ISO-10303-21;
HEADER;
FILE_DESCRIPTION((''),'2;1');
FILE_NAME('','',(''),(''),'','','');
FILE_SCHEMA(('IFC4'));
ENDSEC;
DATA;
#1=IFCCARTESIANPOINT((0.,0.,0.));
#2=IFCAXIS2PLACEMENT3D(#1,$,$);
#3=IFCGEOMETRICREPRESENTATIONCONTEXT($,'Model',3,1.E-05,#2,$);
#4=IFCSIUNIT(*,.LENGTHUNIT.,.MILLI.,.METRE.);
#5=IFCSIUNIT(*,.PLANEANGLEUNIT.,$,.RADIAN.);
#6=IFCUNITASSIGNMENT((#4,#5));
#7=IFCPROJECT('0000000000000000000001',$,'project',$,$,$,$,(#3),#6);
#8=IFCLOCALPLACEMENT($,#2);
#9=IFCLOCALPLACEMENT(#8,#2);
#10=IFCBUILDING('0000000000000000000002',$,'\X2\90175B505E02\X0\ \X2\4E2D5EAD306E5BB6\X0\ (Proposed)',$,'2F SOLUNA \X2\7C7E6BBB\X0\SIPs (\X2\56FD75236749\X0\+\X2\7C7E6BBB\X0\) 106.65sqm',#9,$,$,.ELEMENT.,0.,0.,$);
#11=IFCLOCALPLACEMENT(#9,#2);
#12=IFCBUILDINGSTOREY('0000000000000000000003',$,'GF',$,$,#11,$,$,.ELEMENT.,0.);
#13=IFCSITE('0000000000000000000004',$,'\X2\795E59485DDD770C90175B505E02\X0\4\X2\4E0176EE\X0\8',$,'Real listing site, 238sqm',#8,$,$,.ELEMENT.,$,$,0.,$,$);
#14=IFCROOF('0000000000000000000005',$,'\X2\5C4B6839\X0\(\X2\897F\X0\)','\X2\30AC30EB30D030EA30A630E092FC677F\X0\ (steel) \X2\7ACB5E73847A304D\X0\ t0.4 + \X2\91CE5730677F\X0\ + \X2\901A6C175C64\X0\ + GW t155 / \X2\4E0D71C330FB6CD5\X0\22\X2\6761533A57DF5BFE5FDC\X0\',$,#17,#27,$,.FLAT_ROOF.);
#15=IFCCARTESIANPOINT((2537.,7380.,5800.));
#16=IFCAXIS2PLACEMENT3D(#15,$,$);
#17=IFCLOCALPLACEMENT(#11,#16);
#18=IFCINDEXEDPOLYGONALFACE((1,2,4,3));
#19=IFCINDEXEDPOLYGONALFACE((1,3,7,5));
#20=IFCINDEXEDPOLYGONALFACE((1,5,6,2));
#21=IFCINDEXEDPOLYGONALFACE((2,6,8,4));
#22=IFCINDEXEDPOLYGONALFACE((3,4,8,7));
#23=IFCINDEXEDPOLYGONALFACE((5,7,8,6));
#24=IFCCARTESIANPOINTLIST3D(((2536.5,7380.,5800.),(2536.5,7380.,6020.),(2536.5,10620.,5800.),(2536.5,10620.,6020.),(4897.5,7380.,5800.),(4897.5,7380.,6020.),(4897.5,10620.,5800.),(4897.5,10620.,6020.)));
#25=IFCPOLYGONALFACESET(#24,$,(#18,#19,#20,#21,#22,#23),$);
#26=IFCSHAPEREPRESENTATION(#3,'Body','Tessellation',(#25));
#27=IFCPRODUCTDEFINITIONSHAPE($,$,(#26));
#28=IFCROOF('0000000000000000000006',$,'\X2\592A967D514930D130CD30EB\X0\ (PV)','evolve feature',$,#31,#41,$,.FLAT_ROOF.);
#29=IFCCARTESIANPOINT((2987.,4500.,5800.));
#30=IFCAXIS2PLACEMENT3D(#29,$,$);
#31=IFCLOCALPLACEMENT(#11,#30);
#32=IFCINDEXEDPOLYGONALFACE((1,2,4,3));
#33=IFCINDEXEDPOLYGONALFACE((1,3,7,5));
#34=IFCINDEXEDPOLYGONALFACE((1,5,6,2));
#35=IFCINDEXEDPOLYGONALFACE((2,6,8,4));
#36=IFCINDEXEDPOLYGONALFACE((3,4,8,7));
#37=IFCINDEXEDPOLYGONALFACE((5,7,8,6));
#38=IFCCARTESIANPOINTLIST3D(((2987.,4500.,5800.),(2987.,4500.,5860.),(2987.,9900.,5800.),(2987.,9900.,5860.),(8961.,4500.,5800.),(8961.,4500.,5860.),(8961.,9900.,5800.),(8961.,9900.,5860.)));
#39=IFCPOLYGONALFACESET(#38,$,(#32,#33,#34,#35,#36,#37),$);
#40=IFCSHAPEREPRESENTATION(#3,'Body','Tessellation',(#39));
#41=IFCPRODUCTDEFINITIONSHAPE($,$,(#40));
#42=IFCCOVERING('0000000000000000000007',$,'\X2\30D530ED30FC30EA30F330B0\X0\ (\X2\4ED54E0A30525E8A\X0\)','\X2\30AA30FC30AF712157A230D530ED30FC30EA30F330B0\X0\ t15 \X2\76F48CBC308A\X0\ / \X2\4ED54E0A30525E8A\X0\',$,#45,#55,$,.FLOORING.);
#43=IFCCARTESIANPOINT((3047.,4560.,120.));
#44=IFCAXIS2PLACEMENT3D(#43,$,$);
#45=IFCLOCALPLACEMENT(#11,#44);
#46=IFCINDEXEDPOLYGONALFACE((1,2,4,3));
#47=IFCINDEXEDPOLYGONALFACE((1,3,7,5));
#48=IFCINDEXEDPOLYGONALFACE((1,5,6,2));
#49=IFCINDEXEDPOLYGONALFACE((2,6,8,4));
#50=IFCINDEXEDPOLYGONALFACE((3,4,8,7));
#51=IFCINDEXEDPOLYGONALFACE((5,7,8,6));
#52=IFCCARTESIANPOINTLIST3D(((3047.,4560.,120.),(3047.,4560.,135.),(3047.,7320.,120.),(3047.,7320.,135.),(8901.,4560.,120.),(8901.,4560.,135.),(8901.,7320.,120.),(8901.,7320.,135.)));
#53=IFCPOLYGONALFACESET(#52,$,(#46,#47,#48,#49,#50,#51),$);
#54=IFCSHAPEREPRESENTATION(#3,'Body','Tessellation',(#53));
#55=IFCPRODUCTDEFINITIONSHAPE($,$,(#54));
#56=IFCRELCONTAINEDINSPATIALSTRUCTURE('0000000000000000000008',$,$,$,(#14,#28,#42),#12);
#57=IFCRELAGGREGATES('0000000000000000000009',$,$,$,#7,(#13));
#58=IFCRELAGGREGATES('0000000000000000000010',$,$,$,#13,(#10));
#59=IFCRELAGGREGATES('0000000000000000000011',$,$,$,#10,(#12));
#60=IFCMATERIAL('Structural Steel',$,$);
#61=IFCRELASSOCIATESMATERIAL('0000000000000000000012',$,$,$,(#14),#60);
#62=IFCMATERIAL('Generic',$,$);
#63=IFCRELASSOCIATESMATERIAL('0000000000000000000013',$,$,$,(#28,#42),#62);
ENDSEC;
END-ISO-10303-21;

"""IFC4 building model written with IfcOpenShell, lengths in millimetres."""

from ifc_helpers import new_model, si_unit, frame, frame_2d, origin, place, context, project, spatial, rectangle, extrude, material, element, save


model = new_model("IFC4")

# Units and contexts
model_context = context("Model", 3, precision=1e-05, world=origin())
ifc_project = project(units=[si_unit("LENGTHUNIT", "METRE", prefix="MILLI"), si_unit("PLANEANGLEUNIT", "RADIAN")], contexts=[model_context])

# Site, building, storey
site_placement = place(None, origin())
site = spatial("IfcSite", under=ifc_project, at=site_placement, Name="神奈川県逗子市4丁目8", ObjectType="Real listing site, 238sqm", CompositionType="ELEMENT", RefElevation=0.0)
building_placement = place(site_placement, origin())
building = spatial("IfcBuilding", under=site, at=building_placement, Name="逗子市 中庭の家 (Proposed)", ObjectType="2F SOLUNA 籾殻SIPs (国産杉+籾殻) 106.65sqm", CompositionType="ELEMENT", ElevationOfRefHeight=0.0, ElevationOfTerrain=0.0)
storey_placement = place(building_placement, origin())
storey = spatial("IfcBuildingStorey", under=building, at=storey_placement, Name="GF", CompositionType="ELEMENT", Elevation=0.0)

# Shared definitions
ifc_material_1 = material(Name="Generic")

# Roofs
ifc_material_2 = material(Name="Structural Steel")
roof_1_placement = place(storey_placement, frame((2537.0, 7380.0, 5800.0)))
element("IfcRoof", 1, at=roof_1_placement, inside=storey, material=ifc_material_2, Name="屋根(西)", Description="ガルバリウム鋼板 (steel) 立平葺き t0.4 + 野地板 + 通気層 + GW t155 / 不燃・法22条区域対応", PredefinedType="FLAT_ROOF", context=model_context, shape_type="SweptSolid", body=[
    extrude(rectangle(XDim=2361.0, YDim=3240.0, at=frame_2d((1180.0, 1620.0))), frame((2537.0, 7380.0, 5800.0)), (0.0, 0.0, 1.0), 220.0),
])
roof_2_placement = place(storey_placement, frame((2987.0, 4500.0, 5800.0)))
element("IfcRoof", 2, at=roof_2_placement, inside=storey, material=ifc_material_1, Name="太陽光パネル (PV)", Description="evolve feature", PredefinedType="FLAT_ROOF", context=model_context, shape_type="SweptSolid", body=[
    extrude(rectangle(XDim=5974.0, YDim=5400.0, at=frame_2d((2987.0, 2700.0))), frame((2987.0, 4500.0, 5800.0)), (0.0, 0.0, 1.0), 60.0),
])

# Covering
covering_placement = place(storey_placement, frame((3047.0, 4560.0, 120.0)))
element("IfcCovering", 3, at=covering_placement, inside=storey, material=ifc_material_1, Name="フローリング (仕上げ床)", Description="オーク無垢フローリング t15 直貼り / 仕上げ床", PredefinedType="FLOORING", context=model_context, shape_type="SweptSolid", body=[
    extrude(rectangle(XDim=5854.0, YDim=2760.0, at=frame_2d((2927.0, 1380.0))), frame((3047.0, 4560.0, 120.0)), (0.0, 0.0, 1.0), 15.0),
])

save(model, "model.ifc")
